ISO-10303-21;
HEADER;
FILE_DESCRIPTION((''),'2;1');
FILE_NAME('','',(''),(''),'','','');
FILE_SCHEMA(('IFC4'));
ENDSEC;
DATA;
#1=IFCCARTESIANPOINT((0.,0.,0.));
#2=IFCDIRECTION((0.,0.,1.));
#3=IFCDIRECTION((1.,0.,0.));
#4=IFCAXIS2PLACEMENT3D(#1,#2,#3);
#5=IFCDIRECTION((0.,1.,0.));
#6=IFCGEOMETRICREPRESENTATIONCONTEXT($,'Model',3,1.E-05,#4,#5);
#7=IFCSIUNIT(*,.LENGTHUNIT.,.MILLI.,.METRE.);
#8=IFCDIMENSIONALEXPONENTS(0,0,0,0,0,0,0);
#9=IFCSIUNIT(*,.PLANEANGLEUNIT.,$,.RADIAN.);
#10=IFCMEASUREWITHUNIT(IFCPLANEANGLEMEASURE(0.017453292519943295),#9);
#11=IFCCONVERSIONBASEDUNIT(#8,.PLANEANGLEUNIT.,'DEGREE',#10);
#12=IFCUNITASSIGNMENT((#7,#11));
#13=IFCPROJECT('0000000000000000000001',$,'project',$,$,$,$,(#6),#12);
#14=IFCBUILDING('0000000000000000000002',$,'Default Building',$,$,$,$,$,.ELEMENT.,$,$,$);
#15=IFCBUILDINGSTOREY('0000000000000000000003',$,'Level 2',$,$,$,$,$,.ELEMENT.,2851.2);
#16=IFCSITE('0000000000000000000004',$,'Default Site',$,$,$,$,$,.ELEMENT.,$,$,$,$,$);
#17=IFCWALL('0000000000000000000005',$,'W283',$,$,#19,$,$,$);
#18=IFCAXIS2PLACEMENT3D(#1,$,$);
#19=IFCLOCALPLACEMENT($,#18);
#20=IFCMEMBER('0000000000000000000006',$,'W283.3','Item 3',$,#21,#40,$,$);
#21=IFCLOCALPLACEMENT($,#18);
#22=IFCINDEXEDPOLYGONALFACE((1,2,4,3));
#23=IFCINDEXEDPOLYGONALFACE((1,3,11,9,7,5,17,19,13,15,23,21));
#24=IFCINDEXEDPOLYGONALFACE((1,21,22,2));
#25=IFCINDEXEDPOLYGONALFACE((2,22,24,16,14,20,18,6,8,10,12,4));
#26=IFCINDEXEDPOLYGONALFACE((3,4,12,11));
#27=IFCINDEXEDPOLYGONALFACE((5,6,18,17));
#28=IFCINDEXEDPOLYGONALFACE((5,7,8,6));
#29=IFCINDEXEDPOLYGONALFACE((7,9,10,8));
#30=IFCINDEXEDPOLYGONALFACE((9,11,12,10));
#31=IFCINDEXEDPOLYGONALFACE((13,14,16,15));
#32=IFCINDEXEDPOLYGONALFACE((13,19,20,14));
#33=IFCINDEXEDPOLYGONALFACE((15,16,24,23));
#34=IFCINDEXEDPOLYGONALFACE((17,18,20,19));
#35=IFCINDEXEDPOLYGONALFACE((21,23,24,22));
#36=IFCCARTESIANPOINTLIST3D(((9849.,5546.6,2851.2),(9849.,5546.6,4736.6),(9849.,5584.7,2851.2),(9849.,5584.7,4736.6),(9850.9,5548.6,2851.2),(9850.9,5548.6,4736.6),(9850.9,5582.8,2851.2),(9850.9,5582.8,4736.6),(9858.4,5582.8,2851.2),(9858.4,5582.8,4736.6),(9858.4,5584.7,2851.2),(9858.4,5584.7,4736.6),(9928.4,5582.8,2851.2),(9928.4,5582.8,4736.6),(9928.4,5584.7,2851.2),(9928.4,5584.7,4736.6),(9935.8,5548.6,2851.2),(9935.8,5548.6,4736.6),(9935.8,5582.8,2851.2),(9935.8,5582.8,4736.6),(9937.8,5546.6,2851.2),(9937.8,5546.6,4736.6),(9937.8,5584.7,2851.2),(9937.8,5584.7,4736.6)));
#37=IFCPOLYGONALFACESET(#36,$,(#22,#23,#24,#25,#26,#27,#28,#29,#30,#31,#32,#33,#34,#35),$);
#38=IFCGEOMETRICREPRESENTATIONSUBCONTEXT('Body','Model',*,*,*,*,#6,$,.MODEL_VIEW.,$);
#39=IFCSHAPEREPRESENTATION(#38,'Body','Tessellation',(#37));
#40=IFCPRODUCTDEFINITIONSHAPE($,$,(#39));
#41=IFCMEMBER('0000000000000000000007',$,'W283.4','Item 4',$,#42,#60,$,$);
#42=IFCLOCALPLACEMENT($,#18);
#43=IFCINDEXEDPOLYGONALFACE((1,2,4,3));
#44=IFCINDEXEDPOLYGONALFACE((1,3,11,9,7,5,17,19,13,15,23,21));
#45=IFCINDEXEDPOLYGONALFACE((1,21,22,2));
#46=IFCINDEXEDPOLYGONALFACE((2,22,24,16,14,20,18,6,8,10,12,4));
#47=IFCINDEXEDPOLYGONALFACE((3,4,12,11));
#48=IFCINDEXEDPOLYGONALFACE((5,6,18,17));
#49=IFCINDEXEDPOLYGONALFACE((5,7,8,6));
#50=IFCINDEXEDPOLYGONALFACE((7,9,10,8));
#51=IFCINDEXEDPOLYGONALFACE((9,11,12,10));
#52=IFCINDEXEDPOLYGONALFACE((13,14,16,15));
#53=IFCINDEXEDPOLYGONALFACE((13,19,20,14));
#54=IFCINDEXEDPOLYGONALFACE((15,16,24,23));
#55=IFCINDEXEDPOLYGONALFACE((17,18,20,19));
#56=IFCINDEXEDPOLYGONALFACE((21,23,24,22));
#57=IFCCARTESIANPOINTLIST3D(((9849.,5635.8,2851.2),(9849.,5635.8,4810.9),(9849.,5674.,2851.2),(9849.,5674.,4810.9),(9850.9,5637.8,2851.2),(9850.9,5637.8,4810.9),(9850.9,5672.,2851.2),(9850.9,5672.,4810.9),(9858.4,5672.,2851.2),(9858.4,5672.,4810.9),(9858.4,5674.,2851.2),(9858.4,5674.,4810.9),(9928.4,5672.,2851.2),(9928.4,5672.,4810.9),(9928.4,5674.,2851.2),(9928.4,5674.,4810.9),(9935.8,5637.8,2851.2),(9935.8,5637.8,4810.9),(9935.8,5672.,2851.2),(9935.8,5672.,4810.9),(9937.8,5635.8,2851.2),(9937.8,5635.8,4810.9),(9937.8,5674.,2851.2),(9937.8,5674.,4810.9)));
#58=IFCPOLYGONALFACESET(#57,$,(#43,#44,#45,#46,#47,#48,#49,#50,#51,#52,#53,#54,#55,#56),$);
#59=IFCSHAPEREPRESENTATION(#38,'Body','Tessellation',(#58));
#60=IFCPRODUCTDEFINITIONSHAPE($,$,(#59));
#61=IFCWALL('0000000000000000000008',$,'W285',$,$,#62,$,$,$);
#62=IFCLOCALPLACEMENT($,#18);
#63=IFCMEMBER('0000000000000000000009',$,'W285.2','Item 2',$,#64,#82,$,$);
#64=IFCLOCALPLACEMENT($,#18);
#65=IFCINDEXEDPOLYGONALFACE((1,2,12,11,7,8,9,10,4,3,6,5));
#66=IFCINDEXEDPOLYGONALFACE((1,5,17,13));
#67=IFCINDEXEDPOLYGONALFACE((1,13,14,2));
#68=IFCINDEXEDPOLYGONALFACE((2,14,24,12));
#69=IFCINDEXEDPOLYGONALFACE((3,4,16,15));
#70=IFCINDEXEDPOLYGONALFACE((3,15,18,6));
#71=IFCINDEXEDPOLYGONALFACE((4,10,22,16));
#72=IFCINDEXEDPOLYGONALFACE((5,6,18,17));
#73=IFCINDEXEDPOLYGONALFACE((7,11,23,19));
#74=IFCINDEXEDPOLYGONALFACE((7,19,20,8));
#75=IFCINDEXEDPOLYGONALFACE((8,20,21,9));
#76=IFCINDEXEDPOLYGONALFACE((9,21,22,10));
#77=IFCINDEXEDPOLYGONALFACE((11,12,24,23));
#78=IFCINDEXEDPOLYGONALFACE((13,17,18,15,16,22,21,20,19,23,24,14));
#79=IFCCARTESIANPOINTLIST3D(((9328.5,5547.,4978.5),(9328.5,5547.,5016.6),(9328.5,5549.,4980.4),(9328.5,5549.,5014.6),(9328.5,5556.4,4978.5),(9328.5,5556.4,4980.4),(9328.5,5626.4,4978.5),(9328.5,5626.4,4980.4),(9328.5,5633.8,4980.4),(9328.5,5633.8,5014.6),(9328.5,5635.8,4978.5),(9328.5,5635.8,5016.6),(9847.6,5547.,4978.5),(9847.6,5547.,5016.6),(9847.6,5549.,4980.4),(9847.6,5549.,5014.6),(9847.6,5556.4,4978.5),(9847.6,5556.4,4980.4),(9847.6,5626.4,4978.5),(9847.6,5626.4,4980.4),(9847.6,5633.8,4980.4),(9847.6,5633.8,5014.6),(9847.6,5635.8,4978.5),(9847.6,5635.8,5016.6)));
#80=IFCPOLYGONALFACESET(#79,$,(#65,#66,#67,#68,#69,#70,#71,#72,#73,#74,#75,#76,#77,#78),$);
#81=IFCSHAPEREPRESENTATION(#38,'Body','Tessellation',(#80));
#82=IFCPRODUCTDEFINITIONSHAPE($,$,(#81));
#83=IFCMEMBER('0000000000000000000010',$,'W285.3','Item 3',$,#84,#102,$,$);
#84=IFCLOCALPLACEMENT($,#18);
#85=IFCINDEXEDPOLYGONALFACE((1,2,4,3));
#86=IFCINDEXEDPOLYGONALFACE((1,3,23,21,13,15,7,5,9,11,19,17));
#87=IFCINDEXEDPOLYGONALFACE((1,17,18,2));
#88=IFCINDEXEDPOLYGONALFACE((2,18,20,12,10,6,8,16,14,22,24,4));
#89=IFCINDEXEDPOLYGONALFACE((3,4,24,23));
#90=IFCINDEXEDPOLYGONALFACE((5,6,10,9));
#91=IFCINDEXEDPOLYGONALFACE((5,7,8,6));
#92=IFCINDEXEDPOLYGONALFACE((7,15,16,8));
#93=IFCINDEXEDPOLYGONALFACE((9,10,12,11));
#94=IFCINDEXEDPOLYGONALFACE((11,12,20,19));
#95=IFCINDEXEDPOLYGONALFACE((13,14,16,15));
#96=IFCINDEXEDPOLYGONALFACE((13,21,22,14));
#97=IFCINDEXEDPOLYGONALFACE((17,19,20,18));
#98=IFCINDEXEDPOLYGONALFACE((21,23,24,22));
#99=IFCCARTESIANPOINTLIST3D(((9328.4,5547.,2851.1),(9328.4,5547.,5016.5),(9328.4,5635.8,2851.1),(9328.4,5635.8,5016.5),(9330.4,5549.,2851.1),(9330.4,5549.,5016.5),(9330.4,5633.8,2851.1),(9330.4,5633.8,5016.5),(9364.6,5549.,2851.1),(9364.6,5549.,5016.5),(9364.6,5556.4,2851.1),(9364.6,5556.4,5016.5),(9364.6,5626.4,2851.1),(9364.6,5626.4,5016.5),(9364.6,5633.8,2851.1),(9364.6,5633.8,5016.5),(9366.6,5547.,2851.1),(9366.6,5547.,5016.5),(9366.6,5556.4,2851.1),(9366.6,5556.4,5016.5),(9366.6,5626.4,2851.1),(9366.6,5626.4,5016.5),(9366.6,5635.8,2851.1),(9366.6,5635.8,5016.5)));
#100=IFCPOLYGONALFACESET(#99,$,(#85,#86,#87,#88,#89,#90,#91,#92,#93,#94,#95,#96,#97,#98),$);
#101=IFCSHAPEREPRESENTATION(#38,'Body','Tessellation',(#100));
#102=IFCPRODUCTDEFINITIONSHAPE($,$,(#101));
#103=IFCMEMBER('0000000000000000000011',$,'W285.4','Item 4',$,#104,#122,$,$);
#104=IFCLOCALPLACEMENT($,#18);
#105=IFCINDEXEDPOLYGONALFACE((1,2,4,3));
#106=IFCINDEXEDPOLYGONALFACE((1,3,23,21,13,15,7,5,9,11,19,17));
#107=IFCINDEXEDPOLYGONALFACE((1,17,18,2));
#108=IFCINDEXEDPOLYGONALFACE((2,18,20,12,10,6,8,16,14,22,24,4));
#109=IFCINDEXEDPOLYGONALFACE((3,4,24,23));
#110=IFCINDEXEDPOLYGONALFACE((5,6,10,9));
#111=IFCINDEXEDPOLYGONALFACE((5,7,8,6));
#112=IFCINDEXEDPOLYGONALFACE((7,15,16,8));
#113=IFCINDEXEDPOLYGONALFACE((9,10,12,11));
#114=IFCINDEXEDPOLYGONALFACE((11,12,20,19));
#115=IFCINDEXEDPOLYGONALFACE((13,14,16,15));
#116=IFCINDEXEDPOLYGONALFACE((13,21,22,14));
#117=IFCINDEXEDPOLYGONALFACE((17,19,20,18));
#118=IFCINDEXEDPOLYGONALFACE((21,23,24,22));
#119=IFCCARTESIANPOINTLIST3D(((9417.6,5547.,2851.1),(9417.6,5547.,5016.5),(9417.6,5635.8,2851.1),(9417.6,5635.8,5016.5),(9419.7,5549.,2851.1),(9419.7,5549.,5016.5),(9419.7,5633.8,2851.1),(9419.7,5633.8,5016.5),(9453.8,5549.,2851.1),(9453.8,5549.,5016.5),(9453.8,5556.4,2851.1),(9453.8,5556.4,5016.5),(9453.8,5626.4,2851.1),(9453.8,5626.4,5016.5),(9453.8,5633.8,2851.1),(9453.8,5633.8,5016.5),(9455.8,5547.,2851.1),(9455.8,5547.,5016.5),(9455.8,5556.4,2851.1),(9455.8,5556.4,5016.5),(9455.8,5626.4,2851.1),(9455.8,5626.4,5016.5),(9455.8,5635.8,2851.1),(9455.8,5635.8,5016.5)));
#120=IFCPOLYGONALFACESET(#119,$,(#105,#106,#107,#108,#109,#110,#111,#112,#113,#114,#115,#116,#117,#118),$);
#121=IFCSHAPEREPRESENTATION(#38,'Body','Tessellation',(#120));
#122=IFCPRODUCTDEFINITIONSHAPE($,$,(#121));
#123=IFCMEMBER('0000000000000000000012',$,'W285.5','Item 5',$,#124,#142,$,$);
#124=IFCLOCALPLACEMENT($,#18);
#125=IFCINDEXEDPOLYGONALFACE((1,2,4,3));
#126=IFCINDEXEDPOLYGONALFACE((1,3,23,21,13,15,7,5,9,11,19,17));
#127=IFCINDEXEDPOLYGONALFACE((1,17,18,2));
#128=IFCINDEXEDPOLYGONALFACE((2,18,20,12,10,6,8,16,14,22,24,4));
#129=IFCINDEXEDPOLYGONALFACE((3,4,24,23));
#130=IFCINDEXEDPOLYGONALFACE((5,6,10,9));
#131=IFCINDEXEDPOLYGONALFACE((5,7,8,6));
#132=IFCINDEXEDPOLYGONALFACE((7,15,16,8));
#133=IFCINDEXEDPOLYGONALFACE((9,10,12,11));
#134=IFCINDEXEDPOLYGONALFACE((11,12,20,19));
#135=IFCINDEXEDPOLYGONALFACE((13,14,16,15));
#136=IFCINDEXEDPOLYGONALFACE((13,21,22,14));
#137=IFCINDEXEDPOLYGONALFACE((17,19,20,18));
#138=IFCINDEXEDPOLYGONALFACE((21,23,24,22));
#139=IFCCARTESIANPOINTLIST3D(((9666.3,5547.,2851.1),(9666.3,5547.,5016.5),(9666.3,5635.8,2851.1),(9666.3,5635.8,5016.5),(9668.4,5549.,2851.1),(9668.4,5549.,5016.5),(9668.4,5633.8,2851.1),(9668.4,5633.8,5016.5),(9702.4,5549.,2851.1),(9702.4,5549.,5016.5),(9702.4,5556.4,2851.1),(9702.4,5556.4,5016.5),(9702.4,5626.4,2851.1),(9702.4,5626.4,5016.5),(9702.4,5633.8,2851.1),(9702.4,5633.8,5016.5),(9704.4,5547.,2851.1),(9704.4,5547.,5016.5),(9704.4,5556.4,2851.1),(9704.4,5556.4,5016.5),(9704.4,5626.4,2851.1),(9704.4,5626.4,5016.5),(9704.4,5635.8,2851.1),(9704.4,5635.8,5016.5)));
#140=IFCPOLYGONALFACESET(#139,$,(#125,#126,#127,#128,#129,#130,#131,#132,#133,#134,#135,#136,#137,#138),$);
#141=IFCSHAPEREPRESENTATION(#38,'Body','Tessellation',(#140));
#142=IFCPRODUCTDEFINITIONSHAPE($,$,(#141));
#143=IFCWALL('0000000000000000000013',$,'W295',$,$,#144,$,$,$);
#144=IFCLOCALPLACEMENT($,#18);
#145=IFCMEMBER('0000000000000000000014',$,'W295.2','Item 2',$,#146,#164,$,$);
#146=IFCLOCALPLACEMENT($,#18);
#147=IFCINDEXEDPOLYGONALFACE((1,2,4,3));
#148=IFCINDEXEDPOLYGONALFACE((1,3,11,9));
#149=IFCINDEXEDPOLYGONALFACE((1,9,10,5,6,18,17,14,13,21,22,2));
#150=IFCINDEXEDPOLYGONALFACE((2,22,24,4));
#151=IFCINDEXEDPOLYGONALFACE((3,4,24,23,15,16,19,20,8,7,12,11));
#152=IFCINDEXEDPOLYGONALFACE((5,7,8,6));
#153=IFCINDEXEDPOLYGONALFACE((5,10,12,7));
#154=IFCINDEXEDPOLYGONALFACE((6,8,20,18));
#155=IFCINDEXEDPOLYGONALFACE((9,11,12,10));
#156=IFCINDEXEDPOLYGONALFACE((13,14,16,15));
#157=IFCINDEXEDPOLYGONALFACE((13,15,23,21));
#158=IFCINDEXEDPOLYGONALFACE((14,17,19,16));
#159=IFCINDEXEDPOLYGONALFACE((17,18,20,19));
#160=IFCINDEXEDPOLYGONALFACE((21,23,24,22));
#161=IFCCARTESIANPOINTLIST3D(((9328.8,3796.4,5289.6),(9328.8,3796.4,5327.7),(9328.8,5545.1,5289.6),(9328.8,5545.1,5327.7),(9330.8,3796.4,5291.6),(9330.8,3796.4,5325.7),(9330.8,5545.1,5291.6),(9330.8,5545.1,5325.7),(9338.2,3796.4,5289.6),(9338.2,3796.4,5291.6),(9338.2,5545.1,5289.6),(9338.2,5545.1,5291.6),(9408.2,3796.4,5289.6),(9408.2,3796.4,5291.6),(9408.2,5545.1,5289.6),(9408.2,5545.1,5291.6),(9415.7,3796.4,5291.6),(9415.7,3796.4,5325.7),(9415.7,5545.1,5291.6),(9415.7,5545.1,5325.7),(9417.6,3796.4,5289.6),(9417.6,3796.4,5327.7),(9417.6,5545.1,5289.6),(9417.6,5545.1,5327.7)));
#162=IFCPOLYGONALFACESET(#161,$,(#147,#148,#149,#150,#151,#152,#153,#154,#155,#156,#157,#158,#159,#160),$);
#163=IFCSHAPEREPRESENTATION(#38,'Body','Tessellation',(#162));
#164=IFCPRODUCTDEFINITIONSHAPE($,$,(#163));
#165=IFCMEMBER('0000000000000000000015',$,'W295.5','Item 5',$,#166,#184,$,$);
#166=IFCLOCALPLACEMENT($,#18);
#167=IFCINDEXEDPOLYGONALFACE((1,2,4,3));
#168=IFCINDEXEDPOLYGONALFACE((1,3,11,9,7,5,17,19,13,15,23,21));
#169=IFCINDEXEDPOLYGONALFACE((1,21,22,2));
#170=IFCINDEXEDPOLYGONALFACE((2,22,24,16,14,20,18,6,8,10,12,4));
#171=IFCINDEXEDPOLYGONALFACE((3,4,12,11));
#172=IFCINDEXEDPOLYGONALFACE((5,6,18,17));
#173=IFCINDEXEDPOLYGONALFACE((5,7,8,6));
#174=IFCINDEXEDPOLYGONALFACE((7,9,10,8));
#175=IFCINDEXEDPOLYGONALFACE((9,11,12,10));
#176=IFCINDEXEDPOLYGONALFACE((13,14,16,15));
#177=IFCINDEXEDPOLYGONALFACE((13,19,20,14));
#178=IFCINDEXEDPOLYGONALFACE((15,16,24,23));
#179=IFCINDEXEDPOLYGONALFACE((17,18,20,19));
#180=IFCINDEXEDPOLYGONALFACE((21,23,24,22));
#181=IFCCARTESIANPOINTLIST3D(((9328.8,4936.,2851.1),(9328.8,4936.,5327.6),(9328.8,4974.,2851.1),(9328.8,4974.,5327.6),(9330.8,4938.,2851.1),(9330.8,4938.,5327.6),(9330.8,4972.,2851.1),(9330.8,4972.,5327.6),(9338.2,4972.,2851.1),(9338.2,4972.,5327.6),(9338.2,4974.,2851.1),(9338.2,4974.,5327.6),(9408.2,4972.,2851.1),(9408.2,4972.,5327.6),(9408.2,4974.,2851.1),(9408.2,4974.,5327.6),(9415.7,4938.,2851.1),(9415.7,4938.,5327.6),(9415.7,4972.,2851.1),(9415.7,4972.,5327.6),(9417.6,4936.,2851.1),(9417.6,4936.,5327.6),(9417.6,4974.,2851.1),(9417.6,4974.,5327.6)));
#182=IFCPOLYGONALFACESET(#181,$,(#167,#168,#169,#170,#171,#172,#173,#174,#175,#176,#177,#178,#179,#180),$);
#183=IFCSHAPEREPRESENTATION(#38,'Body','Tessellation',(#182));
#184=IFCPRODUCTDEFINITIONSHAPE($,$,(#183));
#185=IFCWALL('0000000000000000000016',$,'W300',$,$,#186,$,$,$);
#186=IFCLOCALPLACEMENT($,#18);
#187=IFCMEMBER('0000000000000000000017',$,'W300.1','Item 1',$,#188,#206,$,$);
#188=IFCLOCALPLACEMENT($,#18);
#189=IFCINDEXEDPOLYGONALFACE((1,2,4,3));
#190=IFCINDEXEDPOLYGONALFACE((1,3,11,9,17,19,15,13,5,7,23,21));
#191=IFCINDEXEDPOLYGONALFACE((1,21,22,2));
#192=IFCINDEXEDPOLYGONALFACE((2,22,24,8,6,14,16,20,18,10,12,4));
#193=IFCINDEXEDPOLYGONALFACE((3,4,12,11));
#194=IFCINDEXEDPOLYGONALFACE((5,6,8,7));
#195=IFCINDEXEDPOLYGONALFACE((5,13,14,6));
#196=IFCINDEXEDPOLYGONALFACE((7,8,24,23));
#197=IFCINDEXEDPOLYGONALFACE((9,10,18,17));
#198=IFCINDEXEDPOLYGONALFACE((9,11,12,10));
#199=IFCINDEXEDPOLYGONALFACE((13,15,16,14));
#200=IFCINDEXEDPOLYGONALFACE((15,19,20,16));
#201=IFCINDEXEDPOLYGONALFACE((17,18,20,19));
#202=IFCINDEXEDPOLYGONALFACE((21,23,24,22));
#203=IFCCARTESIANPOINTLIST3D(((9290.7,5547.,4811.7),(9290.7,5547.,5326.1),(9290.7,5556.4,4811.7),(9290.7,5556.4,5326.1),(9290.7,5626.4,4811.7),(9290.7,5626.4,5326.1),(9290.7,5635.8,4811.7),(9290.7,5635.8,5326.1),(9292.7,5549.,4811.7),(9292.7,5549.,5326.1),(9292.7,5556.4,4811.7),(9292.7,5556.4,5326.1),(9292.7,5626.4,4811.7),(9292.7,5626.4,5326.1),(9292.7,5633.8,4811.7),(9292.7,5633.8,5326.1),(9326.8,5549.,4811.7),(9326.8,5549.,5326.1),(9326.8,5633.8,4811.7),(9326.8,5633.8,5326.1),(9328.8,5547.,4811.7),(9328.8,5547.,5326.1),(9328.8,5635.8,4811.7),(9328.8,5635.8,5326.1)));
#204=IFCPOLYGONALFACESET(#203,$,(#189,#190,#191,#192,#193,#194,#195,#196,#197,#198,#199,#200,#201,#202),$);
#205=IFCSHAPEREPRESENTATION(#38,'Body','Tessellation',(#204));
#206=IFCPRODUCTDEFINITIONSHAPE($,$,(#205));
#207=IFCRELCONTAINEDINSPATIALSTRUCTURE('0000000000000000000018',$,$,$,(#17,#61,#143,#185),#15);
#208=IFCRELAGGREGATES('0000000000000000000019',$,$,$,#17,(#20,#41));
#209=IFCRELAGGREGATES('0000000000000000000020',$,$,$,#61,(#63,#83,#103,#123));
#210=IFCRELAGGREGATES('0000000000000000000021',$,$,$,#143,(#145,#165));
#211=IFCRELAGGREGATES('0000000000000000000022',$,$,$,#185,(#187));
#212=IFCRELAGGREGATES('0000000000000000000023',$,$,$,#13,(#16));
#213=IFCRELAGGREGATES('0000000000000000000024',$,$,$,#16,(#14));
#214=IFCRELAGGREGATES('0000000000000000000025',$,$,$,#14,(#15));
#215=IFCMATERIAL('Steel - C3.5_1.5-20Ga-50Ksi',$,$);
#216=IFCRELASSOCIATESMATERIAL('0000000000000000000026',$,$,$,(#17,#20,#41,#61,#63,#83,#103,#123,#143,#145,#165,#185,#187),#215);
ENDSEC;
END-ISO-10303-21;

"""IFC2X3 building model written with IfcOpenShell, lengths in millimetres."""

from ifc_helpers import new_model, entity, si_unit, converted_unit, direction, frame, origin, origin_with_axes, origin_2d_with_axis, place, context, subcontext, project, spatial, c_section, extrude, material, element, aggregate, save


model = new_model("IFC2X3")

# Units and contexts
model_context = context("Model", 3, precision=1e-05, world=origin_with_axes(), true_north=direction((0.0, 1.0, 0.0)))
body_context = subcontext(model_context, "Body", "Model", "MODEL_VIEW")
ifc_project = project(units=[si_unit("LENGTHUNIT", "METRE", prefix="MILLI"), converted_unit("PLANEANGLEUNIT", "DEGREE", entity("IfcPlaneAngleMeasure", 0.017453292519943295), si_unit("PLANEANGLEUNIT", "RADIAN"), dimensions=[0, 0, 0, 0, 0, 0, 0])], contexts=[model_context])

# Site, building, storey
site = spatial("IfcSite", under=ifc_project, Name="Default Site", CompositionType="ELEMENT")
building = spatial("IfcBuilding", under=site, Name="Default Building", CompositionType="ELEMENT")
storey = spatial("IfcBuildingStorey", under=building, Name="Level 2", CompositionType="ELEMENT", Elevation=2851.2)

# Walls, members
ifc_material_1 = material(Name="Steel - C3.5_1.5-20Ga-50Ksi")
wall_1 = element("IfcWall", 1, inside=storey, material=ifc_material_1, Name="W283")
member_1_placement = place(None, frame((9893.4, 5565.7, 4736.6), z_axis=(0.0, 0.0, -1.0), x_axis=(0.0, 1.0, 0.0)))
member_1 = element("IfcMember", 2, at=member_1_placement, material=ifc_material_1, Name="W283.3", Description="Item 3", context=body_context, shape_type="SweptSolid", body=[
    extrude(c_section(Depth=88.9, Width=38.1, WallThickness=2.0, Girth=9.5, at=origin_2d_with_axis()), origin(), (0.0, 0.0, 1.0), 1885.4),
])
member_2_placement = place(None, frame((9893.4, 5654.9, 4810.9), z_axis=(0.0, 0.0, -1.0), x_axis=(0.0, 1.0, 0.0)))
member_2 = element("IfcMember", 3, at=member_2_placement, material=ifc_material_1, Name="W283.4", Description="Item 4", context=body_context, shape_type="SweptSolid", body=[
    extrude(c_section(Depth=88.9, Width=38.1, WallThickness=2.0, Girth=9.5, at=origin_2d_with_axis()), origin(), (0.0, 0.0, 1.0), 1959.7),
])
aggregate(wall_1, [member_1, member_2])
wall_2 = element("IfcWall", 4, inside=storey, material=ifc_material_1, Name="W285")
member_3_placement = place(None, frame((9847.6, 5591.4, 4997.5), z_axis=(-1.0, 0.0, 0.0), x_axis=(0.0, 0.0, -1.0)))
member_3 = element("IfcMember", 5, at=member_3_placement, material=ifc_material_1, Name="W285.2", Description="Item 2", context=body_context, shape_type="SweptSolid", body=[
    extrude(c_section(Depth=88.9, Width=38.1, WallThickness=2.0, Girth=9.5, at=origin_2d_with_axis()), origin(), (0.0, 0.0, 1.0), 519.1),
])
member_4_placement = place(None, frame((9347.5, 5591.4, 5016.5), z_axis=(0.0, 0.0, -1.0), x_axis=(1.0, 0.0, 0.0)))
member_4 = element("IfcMember", 6, at=member_4_placement, material=ifc_material_1, Name="W285.3", Description="Item 3", context=body_context, shape_type="SweptSolid", body=[
    extrude(c_section(Depth=88.9, Width=38.1, WallThickness=2.0, Girth=9.5, at=origin_2d_with_axis()), origin(), (0.0, 0.0, 1.0), 2165.4),
])
member_5_placement = place(None, frame((9436.7, 5591.4, 5016.5), z_axis=(0.0, 0.0, -1.0), x_axis=(1.0, 0.0, 0.0)))
member_5 = element("IfcMember", 7, at=member_5_placement, material=ifc_material_1, Name="W285.4", Description="Item 4", context=body_context, shape_type="SweptSolid", body=[
    extrude(c_section(Depth=88.9, Width=38.1, WallThickness=2.0, Girth=9.5, at=origin_2d_with_axis()), origin(), (0.0, 0.0, 1.0), 2165.4),
])
member_6_placement = place(None, frame((9685.4, 5591.4, 5016.5), z_axis=(0.0, 0.0, -1.0), x_axis=(1.0, 0.0, 0.0)))
member_6 = element("IfcMember", 8, at=member_6_placement, material=ifc_material_1, Name="W285.5", Description="Item 5", context=body_context, shape_type="SweptSolid", body=[
    extrude(c_section(Depth=88.9, Width=38.1, WallThickness=2.0, Girth=9.5, at=origin_2d_with_axis()), origin(), (0.0, 0.0, 1.0), 2165.4),
])
aggregate(wall_2, [member_3, member_4, member_5, member_6])
wall_3 = element("IfcWall", 9, inside=storey, material=ifc_material_1, Name="W295")
member_7_placement = place(None, frame((9373.2, 5545.1, 5308.6), z_axis=(0.0, -1.0, 0.0), x_axis=(0.0, 0.0, -1.0)))
member_7 = element("IfcMember", 10, at=member_7_placement, material=ifc_material_1, Name="W295.2", Description="Item 2", context=body_context, shape_type="SweptSolid", body=[
    extrude(c_section(Depth=88.9, Width=38.1, WallThickness=2.0, Girth=9.5, at=origin_2d_with_axis()), origin(), (0.0, 0.0, 1.0), 1748.7),
])
member_8_placement = place(None, frame((9373.2, 4955.0, 5327.6), z_axis=(0.0, 0.0, -1.0), x_axis=(0.0, 1.0, 0.0)))
member_8 = element("IfcMember", 11, at=member_8_placement, material=ifc_material_1, Name="W295.5", Description="Item 5", context=body_context, shape_type="SweptSolid", body=[
    extrude(c_section(Depth=88.9, Width=38.1, WallThickness=2.0, Girth=9.5, at=origin_2d_with_axis()), origin(), (0.0, 0.0, 1.0), 2476.5),
])
aggregate(wall_3, [member_7, member_8])
wall_4 = element("IfcWall", 12, inside=storey, material=ifc_material_1, Name="W300")
member_9_placement = place(None, frame((9309.7, 5591.4, 4811.7), z_axis=(0.0, 0.0, 1.0), x_axis=(-1.0, 0.0, 0.0)))
member_9 = element("IfcMember", 13, at=member_9_placement, material=ifc_material_1, Name="W300.1", Description="Item 1", context=body_context, shape_type="SweptSolid", body=[
    extrude(c_section(Depth=88.9, Width=38.1, WallThickness=2.0, Girth=9.5, at=origin_2d_with_axis()), origin(), (0.0, 0.0, 1.0), 514.4),
])
aggregate(wall_4, [member_9])

save(model, "model.ifc")
